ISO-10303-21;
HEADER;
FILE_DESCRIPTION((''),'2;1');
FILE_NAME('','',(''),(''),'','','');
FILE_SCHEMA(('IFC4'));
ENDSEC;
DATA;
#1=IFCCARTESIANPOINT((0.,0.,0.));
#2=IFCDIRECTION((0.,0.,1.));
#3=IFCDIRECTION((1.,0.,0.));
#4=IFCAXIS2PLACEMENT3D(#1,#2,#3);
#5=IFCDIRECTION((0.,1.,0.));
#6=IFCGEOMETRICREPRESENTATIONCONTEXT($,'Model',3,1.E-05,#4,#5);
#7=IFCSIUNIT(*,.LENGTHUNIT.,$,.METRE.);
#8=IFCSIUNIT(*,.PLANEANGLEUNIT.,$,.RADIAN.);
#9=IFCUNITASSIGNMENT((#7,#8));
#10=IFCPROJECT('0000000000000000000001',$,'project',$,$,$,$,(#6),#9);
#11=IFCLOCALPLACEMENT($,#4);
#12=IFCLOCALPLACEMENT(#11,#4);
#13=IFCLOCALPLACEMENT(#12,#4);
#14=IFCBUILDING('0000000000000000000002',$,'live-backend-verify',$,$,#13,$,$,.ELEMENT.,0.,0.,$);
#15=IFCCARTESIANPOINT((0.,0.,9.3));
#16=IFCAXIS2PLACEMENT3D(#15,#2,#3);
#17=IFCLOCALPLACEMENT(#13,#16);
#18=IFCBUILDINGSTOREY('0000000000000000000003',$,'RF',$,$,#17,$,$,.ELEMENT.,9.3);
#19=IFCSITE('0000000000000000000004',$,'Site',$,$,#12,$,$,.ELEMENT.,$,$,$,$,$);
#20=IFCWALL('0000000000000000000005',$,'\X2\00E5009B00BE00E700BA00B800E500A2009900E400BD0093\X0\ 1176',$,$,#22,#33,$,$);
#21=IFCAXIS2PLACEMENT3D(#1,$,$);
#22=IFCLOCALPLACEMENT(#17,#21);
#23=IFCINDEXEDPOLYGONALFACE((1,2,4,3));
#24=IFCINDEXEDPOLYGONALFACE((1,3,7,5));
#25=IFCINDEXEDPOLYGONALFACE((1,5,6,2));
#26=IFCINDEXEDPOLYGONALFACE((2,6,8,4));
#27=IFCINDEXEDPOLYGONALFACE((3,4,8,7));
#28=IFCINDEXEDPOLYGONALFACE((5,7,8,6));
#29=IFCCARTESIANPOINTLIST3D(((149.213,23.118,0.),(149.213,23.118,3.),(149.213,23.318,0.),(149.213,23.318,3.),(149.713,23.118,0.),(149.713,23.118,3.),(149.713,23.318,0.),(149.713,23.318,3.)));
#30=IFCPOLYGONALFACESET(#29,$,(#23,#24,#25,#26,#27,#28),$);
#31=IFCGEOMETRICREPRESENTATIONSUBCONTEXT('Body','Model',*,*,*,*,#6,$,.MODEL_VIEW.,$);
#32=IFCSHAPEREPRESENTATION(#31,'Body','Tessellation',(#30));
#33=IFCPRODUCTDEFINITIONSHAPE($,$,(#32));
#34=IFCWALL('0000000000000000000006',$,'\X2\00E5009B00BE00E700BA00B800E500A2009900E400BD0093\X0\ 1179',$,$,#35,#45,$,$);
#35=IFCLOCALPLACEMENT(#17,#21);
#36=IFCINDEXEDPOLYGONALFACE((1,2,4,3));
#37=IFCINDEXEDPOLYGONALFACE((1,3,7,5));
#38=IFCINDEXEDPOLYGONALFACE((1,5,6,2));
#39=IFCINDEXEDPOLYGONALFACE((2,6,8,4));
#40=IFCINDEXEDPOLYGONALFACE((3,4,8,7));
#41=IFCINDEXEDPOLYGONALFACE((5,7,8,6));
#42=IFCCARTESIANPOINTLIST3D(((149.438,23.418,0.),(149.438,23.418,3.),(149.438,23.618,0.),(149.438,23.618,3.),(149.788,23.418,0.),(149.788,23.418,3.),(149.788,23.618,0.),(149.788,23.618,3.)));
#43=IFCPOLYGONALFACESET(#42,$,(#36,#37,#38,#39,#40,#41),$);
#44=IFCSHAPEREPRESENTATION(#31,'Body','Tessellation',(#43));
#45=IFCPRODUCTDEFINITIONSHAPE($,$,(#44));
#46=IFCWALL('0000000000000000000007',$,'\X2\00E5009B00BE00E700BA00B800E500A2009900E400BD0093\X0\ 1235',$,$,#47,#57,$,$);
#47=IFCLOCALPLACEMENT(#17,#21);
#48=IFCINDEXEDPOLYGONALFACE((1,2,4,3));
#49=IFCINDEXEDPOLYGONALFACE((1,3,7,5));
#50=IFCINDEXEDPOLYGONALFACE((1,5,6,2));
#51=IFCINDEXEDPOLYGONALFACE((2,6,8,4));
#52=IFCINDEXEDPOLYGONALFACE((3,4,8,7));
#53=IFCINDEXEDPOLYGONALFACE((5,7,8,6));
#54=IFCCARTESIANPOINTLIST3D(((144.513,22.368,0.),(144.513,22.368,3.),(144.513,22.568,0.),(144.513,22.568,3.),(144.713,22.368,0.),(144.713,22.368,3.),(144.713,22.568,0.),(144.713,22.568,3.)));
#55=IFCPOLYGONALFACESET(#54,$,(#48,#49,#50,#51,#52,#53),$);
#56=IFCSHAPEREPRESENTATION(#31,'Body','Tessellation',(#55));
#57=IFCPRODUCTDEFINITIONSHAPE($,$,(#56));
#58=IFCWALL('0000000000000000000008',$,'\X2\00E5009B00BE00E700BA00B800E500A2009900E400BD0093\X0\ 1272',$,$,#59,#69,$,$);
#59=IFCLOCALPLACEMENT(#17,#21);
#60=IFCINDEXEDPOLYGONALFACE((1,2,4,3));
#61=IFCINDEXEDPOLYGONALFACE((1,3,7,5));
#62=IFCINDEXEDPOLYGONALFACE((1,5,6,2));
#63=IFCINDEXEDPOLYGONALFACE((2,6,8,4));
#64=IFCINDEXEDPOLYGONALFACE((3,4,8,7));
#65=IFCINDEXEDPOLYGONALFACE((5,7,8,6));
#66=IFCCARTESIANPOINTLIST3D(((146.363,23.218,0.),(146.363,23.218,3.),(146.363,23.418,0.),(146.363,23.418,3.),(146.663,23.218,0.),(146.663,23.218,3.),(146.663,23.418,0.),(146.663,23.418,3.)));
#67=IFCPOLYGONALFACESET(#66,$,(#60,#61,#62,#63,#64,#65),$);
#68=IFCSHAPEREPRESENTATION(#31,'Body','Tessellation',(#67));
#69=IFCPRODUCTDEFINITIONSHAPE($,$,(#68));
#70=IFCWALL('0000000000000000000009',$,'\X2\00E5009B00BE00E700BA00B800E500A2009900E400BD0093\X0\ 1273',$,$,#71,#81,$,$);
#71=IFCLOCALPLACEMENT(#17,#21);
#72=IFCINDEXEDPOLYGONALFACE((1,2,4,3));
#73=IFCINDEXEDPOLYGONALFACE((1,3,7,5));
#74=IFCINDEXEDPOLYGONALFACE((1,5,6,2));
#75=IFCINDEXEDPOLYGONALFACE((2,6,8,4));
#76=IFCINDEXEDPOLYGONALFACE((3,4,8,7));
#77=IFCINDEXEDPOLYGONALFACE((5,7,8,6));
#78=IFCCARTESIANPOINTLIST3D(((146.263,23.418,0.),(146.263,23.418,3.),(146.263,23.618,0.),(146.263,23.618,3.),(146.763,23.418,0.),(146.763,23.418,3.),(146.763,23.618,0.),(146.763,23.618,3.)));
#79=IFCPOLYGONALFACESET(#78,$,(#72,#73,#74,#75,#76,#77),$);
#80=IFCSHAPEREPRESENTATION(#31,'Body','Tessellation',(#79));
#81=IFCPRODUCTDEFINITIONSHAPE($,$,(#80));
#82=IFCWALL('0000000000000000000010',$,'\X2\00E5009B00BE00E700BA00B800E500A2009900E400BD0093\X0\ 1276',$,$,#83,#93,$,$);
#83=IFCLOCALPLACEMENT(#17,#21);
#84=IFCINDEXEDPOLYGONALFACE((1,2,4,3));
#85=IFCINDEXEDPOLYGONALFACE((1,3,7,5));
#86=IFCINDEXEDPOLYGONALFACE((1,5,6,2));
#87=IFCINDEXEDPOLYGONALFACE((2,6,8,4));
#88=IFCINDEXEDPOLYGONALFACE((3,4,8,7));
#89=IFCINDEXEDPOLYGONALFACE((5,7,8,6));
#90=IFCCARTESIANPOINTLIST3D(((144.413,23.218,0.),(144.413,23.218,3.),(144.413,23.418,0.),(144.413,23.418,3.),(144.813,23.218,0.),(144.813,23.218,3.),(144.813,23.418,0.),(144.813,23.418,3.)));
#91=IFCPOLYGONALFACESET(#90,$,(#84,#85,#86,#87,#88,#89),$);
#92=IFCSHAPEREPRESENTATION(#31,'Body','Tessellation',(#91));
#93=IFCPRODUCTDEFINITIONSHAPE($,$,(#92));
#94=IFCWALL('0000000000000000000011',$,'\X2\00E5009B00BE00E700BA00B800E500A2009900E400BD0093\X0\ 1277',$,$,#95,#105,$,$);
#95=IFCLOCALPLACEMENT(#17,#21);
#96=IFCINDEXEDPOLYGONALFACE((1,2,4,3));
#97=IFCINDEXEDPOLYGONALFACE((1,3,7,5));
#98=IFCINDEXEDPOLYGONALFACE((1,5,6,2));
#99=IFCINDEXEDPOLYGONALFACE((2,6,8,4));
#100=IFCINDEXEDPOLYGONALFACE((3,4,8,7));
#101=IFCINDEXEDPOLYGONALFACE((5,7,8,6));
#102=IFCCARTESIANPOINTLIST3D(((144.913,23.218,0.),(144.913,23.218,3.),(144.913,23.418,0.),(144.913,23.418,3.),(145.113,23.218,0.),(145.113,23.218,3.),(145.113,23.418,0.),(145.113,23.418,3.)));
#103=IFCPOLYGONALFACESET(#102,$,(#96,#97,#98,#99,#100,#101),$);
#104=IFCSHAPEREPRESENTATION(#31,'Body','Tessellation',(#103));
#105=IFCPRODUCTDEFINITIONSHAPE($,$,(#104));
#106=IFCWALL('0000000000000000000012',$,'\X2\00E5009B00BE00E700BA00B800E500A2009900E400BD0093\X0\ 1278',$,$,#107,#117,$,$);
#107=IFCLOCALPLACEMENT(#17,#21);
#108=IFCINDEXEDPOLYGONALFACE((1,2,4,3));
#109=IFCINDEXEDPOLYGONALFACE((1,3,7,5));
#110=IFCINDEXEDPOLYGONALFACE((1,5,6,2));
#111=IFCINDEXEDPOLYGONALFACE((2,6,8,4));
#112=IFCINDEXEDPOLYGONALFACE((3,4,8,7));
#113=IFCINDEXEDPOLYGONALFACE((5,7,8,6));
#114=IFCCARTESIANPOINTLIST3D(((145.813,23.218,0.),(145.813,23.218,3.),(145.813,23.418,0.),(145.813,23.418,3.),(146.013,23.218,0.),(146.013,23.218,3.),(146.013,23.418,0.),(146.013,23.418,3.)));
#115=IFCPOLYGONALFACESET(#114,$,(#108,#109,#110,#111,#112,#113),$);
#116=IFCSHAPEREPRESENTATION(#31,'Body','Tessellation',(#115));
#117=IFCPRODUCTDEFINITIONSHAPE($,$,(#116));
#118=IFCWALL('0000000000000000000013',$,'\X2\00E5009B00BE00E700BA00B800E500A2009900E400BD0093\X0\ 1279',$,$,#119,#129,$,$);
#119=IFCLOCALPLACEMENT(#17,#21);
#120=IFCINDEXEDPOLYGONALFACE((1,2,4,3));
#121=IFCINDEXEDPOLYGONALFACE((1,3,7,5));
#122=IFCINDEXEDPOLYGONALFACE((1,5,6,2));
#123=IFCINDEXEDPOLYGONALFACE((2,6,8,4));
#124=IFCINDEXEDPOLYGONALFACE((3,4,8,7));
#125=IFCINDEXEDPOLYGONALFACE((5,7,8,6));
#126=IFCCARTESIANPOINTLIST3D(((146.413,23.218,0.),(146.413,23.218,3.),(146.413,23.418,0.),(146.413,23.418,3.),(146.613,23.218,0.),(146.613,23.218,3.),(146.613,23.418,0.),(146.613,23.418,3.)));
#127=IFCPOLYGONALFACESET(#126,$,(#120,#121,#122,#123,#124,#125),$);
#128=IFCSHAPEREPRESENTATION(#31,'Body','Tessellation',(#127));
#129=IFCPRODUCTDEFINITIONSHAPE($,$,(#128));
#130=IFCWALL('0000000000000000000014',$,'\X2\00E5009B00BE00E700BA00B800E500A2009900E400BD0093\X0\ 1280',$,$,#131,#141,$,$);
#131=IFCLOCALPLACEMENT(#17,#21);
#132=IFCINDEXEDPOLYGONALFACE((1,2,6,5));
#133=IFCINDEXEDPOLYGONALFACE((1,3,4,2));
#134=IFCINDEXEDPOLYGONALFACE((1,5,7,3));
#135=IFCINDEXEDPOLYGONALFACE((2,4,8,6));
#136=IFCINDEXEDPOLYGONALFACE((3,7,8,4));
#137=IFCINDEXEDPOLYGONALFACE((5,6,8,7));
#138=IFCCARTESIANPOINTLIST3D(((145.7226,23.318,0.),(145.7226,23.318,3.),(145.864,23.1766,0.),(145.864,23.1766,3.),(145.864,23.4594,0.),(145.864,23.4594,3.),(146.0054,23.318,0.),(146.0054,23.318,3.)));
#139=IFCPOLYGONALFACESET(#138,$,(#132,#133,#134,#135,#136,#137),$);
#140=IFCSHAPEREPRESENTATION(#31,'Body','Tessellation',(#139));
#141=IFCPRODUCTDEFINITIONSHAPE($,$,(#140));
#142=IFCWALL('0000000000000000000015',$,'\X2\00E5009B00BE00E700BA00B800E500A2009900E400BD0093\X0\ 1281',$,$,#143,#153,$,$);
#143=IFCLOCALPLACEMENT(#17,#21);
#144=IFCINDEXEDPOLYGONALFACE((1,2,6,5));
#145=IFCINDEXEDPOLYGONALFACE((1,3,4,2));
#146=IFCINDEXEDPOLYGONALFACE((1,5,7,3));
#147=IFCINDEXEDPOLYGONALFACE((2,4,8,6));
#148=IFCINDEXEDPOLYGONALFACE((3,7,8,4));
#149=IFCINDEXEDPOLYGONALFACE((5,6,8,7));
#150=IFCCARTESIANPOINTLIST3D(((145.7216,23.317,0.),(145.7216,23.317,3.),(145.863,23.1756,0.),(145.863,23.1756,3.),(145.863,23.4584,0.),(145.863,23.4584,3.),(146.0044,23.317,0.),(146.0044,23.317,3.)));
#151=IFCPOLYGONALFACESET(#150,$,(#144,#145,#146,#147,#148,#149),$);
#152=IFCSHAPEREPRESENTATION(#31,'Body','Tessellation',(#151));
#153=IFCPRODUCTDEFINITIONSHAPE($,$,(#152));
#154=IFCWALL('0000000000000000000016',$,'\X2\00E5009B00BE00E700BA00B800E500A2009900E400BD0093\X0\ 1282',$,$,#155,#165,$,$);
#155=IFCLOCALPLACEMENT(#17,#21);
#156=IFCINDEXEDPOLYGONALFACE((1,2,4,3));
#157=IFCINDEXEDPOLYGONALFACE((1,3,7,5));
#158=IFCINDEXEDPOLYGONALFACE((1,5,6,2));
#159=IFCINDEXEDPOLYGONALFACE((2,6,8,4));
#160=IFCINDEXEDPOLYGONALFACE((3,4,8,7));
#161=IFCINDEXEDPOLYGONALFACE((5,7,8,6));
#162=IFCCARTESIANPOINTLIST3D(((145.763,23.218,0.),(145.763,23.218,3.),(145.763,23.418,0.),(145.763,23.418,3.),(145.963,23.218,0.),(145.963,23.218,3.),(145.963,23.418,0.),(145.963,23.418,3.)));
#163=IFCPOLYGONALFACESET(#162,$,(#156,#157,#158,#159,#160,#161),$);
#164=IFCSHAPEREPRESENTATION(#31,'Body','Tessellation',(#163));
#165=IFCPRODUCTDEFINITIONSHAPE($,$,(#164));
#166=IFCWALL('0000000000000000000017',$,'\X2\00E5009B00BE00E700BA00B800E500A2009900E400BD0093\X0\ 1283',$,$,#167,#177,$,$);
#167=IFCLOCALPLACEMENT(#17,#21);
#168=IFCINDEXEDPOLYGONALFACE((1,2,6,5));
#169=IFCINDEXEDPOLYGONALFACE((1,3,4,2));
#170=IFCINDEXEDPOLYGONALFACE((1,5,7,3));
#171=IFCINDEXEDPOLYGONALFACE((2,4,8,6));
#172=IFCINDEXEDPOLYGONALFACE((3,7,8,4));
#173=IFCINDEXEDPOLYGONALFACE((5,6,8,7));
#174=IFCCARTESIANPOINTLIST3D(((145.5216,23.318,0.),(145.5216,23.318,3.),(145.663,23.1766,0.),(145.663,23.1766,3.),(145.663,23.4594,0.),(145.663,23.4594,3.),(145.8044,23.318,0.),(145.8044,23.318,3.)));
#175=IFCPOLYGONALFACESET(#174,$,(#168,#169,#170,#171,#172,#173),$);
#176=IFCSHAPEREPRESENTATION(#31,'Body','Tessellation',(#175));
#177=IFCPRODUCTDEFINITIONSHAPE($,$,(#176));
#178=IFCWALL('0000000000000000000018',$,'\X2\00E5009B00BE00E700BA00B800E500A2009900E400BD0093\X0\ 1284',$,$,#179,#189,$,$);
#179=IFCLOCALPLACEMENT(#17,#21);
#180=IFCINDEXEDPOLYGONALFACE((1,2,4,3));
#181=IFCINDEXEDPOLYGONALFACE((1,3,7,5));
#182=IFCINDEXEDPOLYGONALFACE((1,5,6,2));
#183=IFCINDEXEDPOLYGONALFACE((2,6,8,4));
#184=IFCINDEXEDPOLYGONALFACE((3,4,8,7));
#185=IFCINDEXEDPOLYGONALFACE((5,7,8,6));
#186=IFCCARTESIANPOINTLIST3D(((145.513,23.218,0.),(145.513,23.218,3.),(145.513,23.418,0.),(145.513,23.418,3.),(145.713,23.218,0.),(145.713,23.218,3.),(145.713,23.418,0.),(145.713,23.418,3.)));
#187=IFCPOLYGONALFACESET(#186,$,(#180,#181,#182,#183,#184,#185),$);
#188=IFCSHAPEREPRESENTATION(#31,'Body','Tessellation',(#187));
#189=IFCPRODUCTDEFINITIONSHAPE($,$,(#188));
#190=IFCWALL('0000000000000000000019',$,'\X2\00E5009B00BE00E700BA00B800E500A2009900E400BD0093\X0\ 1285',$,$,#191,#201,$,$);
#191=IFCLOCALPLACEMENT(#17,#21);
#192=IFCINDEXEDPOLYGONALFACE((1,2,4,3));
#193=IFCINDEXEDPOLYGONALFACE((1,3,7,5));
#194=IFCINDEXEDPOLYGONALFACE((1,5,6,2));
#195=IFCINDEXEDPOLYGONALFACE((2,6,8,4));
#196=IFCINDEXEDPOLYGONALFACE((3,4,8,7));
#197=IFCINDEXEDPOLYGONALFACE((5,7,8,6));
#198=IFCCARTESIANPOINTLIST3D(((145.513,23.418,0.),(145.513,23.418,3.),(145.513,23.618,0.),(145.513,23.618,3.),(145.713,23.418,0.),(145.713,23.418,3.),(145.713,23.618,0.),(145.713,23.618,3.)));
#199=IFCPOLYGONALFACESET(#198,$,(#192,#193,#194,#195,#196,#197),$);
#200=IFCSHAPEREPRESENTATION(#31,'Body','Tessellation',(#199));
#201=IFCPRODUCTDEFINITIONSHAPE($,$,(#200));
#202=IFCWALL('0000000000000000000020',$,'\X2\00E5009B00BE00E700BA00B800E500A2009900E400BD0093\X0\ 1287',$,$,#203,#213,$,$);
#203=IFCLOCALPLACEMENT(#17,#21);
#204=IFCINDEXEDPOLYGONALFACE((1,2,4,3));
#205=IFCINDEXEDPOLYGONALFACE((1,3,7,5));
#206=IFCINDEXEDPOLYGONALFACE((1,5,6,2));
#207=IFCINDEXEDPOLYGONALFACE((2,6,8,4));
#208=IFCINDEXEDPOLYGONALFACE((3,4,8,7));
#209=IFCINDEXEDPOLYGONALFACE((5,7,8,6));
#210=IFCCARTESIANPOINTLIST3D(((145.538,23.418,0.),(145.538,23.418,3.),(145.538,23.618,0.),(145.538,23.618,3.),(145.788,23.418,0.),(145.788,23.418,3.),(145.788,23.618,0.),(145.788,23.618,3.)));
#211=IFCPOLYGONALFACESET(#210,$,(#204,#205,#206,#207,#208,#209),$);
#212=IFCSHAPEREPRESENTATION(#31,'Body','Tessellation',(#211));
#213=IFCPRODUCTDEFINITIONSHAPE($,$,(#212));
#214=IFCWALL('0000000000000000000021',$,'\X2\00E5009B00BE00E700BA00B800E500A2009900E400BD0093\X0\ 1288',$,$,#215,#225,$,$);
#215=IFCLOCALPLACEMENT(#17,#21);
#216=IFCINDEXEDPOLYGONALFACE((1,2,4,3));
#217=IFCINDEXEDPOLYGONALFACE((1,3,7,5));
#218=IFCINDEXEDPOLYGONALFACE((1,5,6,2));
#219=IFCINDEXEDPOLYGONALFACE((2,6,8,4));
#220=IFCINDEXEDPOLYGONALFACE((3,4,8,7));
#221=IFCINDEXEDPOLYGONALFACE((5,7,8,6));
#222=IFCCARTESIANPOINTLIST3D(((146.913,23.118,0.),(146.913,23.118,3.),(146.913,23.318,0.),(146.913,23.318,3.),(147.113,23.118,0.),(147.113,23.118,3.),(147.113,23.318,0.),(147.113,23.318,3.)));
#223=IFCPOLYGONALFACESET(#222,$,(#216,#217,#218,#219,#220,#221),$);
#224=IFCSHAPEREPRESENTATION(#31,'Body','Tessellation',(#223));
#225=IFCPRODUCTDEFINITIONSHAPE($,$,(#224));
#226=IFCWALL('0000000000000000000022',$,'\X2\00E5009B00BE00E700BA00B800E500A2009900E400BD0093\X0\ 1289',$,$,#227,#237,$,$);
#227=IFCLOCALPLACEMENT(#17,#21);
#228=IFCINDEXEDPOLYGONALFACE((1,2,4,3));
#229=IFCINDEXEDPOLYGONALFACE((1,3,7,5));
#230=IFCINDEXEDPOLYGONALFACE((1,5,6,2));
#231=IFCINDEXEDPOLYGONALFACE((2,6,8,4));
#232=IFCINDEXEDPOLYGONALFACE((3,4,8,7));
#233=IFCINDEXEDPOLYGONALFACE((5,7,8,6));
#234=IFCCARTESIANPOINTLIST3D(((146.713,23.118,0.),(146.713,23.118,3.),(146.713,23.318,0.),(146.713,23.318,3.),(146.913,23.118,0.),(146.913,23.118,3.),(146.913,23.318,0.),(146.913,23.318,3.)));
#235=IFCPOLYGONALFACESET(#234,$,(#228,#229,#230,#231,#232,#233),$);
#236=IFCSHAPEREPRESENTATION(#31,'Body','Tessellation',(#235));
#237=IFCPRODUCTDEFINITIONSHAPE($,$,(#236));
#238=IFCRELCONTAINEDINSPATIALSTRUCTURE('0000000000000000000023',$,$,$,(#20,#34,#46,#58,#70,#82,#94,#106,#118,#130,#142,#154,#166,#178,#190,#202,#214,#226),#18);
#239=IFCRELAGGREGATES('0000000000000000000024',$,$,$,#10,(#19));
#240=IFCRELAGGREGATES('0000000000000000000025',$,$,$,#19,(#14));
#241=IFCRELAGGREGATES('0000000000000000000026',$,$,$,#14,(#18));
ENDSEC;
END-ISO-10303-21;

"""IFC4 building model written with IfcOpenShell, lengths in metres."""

from ifc_helpers import new_model, si_unit, direction, frame, frame_2d, origin_with_axes, place, context, subcontext, project, spatial, rectangle, extrude, element, save


model = new_model("IFC4")

# Units and contexts
model_context = context("Model", 3, precision=1e-05, world=origin_with_axes(), true_north=direction((0.0, 1.0, 0.0)))
body_context = subcontext(model_context, "Body", "Model", "MODEL_VIEW")
ifc_project = project(units=[si_unit("LENGTHUNIT", "METRE"), si_unit("PLANEANGLEUNIT", "RADIAN")], contexts=[model_context])

# Site, building, storey
placement = place(None, origin_with_axes())
site_placement = place(placement, origin_with_axes())
site = spatial("IfcSite", under=ifc_project, at=site_placement, Name="Site", CompositionType="ELEMENT")
building_placement = place(site_placement, origin_with_axes())
building = spatial("IfcBuilding", under=site, at=building_placement, Name="live-backend-verify", CompositionType="ELEMENT", ElevationOfRefHeight=0.0, ElevationOfTerrain=0.0)
storey_placement = place(building_placement, frame((0.0, 0.0, 9.3), z_axis=(0.0, 0.0, 1.0), x_axis=(1.0, 0.0, 0.0)))
storey = spatial("IfcBuildingStorey", under=building, at=storey_placement, Name="RF", CompositionType="ELEMENT", Elevation=9.3)

# Walls
wall_1_placement = place(storey_placement, frame((149.463, 23.218, 0.0), z_axis=(0.0, 0.0, 1.0), x_axis=(1.0, 0.0, 0.0)))
element("IfcWall", 1, at=wall_1_placement, inside=storey, Name="å\u009b¾çº¸å¢\u0099ä½\u0093 1176", context=body_context, shape_type="SweptSolid", body=[
    extrude(rectangle(XDim=0.5, YDim=0.2, at=frame_2d((0.0, 0.0), x_axis=(1.0, 0.0, 0.0))), frame((0.0, 0.0, 0.0), z_axis=(0.0, 0.0, 1.0)), (0.0, 0.0, 1.0), 3.0),
])
wall_2_placement = place(storey_placement, frame((149.613, 23.518, 0.0), z_axis=(0.0, 0.0, 1.0), x_axis=(1.0, 0.0, 0.0)))
element("IfcWall", 2, at=wall_2_placement, inside=storey, Name="å\u009b¾çº¸å¢\u0099ä½\u0093 1179", context=body_context, shape_type="SweptSolid", body=[
    extrude(rectangle(XDim=0.35, YDim=0.2, at=frame_2d((0.0, 0.0), x_axis=(1.0, 0.0, 0.0))), frame((0.0, 0.0, 0.0), z_axis=(0.0, 0.0, 1.0)), (0.0, 0.0, 1.0), 3.0),
])
wall_3_placement = place(storey_placement, frame((144.613, 22.468, 0.0), z_axis=(0.0, 0.0, 1.0), x_axis=(-1.0, 0.0, 0.0)))
element("IfcWall", 3, at=wall_3_placement, inside=storey, Name="å\u009b¾çº¸å¢\u0099ä½\u0093 1235", context=body_context, shape_type="SweptSolid", body=[
    extrude(rectangle(XDim=0.2, YDim=0.2, at=frame_2d((0.0, 0.0), x_axis=(1.0, 0.0, 0.0))), frame((0.0, 0.0, 0.0), z_axis=(0.0, 0.0, 1.0)), (0.0, 0.0, 1.0), 3.0),
])
wall_4_placement = place(storey_placement, frame((146.513, 23.318, 0.0), z_axis=(0.0, 0.0, 1.0), x_axis=(1.0, 0.0, 0.0)))
element("IfcWall", 4, at=wall_4_placement, inside=storey, Name="å\u009b¾çº¸å¢\u0099ä½\u0093 1272", context=body_context, shape_type="SweptSolid", body=[
    extrude(rectangle(XDim=0.3, YDim=0.2, at=frame_2d((0.0, 0.0), x_axis=(1.0, 0.0, 0.0))), frame((0.0, 0.0, 0.0), z_axis=(0.0, 0.0, 1.0)), (0.0, 0.0, 1.0), 3.0),
])
wall_5_placement = place(storey_placement, frame((146.513, 23.518, 0.0), z_axis=(0.0, 0.0, 1.0), x_axis=(1.0, 0.0, 0.0)))
element("IfcWall", 5, at=wall_5_placement, inside=storey, Name="å\u009b¾çº¸å¢\u0099ä½\u0093 1273", context=body_context, shape_type="SweptSolid", body=[
    extrude(rectangle(XDim=0.5, YDim=0.2, at=frame_2d((0.0, 0.0), x_axis=(1.0, 0.0, 0.0))), frame((0.0, 0.0, 0.0), z_axis=(0.0, 0.0, 1.0)), (0.0, 0.0, 1.0), 3.0),
])
wall_6_placement = place(storey_placement, frame((144.613, 23.318, 0.0), z_axis=(0.0, 0.0, 1.0), x_axis=(1.0, 0.0, 0.0)))
element("IfcWall", 6, at=wall_6_placement, inside=storey, Name="å\u009b¾çº¸å¢\u0099ä½\u0093 1276", context=body_context, shape_type="SweptSolid", body=[
    extrude(rectangle(XDim=0.4, YDim=0.2, at=frame_2d((0.0, 0.0), x_axis=(1.0, 0.0, 0.0))), frame((0.0, 0.0, 0.0), z_axis=(0.0, 0.0, 1.0)), (0.0, 0.0, 1.0), 3.0),
])
for number, where, z_axis, x_axis, name in (
    (7, (145.013, 23.318, 0.0), (0.0, 0.0, 1.0), (0.0, 1.0, 0.0), "å\u009b¾çº¸å¢\u0099ä½\u0093 1277"),
    (8, (145.913, 23.318, 0.0), (0.0, 0.0, 1.0), (0.0, 1.0, 0.0), "å\u009b¾çº¸å¢\u0099ä½\u0093 1278"),
    (9, (146.513, 23.318, 0.0), (0.0, 0.0, 1.0), (0.0, 1.0, 0.0), "å\u009b¾çº¸å¢\u0099ä½\u0093 1279"),
    (10, (145.864, 23.318, 0.0), (0.0, 0.0, 1.0), (-0.707107, -0.707107, 0.0), "å\u009b¾çº¸å¢\u0099ä½\u0093 1280"),
    (11, (145.863, 23.317, 0.0), (0.0, 0.0, 1.0), (0.707107, 0.707107, 0.0), "å\u009b¾çº¸å¢\u0099ä½\u0093 1281"),
    (12, (145.863, 23.318, 0.0), (0.0, 0.0, 1.0), (1.0, 0.0, 0.0), "å\u009b¾çº¸å¢\u0099ä½\u0093 1282"),
    (13, (145.663, 23.318, 0.0), (0.0, 0.0, 1.0), (0.707107, -0.707107, 0.0), "å\u009b¾çº¸å¢\u0099ä½\u0093 1283"),
    (14, (145.613, 23.318, 0.0), (0.0, 0.0, 1.0), (1.0, 0.0, 0.0), "å\u009b¾çº¸å¢\u0099ä½\u0093 1284"),
    (15, (145.613, 23.518, 0.0), (0.0, 0.0, 1.0), (1.0, 0.0, 0.0), "å\u009b¾çº¸å¢\u0099ä½\u0093 1285"),
):
    element("IfcWall", number, at=place(storey_placement, frame(where, z_axis=z_axis, x_axis=x_axis)), inside=storey, Name=name, context=body_context, shape_type="SweptSolid", body=[
        extrude(rectangle(XDim=0.2, YDim=0.2, at=frame_2d((0.0, 0.0), x_axis=(1.0, 0.0, 0.0))), frame((0.0, 0.0, 0.0), z_axis=(0.0, 0.0, 1.0)), (0.0, 0.0, 1.0), 3.0),
    ])
wall_7_placement = place(storey_placement, frame((145.663, 23.518, 0.0), z_axis=(0.0, 0.0, 1.0), x_axis=(1.0, 0.0, 0.0)))
element("IfcWall", 16, at=wall_7_placement, inside=storey, Name="å\u009b¾çº¸å¢\u0099ä½\u0093 1287", context=body_context, shape_type="SweptSolid", body=[
    extrude(rectangle(XDim=0.25, YDim=0.2, at=frame_2d((0.0, 0.0), x_axis=(1.0, 0.0, 0.0))), frame((0.0, 0.0, 0.0), z_axis=(0.0, 0.0, 1.0)), (0.0, 0.0, 1.0), 3.0),
])
for number, where, z_axis, x_axis, name in (
    (17, (147.013, 23.218, 0.0), (0.0, 0.0, 1.0), (-1.0, 0.0, 0.0), "å\u009b¾çº¸å¢\u0099ä½\u0093 1288"),
    (18, (146.813, 23.218, 0.0), (0.0, 0.0, 1.0), (0.0, 1.0, 0.0), "å\u009b¾çº¸å¢\u0099ä½\u0093 1289"),
):
    element("IfcWall", number, at=place(storey_placement, frame(where, z_axis=z_axis, x_axis=x_axis)), inside=storey, Name=name, context=body_context, shape_type="SweptSolid", body=[
        extrude(rectangle(XDim=0.2, YDim=0.2, at=frame_2d((0.0, 0.0), x_axis=(1.0, 0.0, 0.0))), frame((0.0, 0.0, 0.0), z_axis=(0.0, 0.0, 1.0)), (0.0, 0.0, 1.0), 3.0),
    ])

save(model, "model.ifc")
